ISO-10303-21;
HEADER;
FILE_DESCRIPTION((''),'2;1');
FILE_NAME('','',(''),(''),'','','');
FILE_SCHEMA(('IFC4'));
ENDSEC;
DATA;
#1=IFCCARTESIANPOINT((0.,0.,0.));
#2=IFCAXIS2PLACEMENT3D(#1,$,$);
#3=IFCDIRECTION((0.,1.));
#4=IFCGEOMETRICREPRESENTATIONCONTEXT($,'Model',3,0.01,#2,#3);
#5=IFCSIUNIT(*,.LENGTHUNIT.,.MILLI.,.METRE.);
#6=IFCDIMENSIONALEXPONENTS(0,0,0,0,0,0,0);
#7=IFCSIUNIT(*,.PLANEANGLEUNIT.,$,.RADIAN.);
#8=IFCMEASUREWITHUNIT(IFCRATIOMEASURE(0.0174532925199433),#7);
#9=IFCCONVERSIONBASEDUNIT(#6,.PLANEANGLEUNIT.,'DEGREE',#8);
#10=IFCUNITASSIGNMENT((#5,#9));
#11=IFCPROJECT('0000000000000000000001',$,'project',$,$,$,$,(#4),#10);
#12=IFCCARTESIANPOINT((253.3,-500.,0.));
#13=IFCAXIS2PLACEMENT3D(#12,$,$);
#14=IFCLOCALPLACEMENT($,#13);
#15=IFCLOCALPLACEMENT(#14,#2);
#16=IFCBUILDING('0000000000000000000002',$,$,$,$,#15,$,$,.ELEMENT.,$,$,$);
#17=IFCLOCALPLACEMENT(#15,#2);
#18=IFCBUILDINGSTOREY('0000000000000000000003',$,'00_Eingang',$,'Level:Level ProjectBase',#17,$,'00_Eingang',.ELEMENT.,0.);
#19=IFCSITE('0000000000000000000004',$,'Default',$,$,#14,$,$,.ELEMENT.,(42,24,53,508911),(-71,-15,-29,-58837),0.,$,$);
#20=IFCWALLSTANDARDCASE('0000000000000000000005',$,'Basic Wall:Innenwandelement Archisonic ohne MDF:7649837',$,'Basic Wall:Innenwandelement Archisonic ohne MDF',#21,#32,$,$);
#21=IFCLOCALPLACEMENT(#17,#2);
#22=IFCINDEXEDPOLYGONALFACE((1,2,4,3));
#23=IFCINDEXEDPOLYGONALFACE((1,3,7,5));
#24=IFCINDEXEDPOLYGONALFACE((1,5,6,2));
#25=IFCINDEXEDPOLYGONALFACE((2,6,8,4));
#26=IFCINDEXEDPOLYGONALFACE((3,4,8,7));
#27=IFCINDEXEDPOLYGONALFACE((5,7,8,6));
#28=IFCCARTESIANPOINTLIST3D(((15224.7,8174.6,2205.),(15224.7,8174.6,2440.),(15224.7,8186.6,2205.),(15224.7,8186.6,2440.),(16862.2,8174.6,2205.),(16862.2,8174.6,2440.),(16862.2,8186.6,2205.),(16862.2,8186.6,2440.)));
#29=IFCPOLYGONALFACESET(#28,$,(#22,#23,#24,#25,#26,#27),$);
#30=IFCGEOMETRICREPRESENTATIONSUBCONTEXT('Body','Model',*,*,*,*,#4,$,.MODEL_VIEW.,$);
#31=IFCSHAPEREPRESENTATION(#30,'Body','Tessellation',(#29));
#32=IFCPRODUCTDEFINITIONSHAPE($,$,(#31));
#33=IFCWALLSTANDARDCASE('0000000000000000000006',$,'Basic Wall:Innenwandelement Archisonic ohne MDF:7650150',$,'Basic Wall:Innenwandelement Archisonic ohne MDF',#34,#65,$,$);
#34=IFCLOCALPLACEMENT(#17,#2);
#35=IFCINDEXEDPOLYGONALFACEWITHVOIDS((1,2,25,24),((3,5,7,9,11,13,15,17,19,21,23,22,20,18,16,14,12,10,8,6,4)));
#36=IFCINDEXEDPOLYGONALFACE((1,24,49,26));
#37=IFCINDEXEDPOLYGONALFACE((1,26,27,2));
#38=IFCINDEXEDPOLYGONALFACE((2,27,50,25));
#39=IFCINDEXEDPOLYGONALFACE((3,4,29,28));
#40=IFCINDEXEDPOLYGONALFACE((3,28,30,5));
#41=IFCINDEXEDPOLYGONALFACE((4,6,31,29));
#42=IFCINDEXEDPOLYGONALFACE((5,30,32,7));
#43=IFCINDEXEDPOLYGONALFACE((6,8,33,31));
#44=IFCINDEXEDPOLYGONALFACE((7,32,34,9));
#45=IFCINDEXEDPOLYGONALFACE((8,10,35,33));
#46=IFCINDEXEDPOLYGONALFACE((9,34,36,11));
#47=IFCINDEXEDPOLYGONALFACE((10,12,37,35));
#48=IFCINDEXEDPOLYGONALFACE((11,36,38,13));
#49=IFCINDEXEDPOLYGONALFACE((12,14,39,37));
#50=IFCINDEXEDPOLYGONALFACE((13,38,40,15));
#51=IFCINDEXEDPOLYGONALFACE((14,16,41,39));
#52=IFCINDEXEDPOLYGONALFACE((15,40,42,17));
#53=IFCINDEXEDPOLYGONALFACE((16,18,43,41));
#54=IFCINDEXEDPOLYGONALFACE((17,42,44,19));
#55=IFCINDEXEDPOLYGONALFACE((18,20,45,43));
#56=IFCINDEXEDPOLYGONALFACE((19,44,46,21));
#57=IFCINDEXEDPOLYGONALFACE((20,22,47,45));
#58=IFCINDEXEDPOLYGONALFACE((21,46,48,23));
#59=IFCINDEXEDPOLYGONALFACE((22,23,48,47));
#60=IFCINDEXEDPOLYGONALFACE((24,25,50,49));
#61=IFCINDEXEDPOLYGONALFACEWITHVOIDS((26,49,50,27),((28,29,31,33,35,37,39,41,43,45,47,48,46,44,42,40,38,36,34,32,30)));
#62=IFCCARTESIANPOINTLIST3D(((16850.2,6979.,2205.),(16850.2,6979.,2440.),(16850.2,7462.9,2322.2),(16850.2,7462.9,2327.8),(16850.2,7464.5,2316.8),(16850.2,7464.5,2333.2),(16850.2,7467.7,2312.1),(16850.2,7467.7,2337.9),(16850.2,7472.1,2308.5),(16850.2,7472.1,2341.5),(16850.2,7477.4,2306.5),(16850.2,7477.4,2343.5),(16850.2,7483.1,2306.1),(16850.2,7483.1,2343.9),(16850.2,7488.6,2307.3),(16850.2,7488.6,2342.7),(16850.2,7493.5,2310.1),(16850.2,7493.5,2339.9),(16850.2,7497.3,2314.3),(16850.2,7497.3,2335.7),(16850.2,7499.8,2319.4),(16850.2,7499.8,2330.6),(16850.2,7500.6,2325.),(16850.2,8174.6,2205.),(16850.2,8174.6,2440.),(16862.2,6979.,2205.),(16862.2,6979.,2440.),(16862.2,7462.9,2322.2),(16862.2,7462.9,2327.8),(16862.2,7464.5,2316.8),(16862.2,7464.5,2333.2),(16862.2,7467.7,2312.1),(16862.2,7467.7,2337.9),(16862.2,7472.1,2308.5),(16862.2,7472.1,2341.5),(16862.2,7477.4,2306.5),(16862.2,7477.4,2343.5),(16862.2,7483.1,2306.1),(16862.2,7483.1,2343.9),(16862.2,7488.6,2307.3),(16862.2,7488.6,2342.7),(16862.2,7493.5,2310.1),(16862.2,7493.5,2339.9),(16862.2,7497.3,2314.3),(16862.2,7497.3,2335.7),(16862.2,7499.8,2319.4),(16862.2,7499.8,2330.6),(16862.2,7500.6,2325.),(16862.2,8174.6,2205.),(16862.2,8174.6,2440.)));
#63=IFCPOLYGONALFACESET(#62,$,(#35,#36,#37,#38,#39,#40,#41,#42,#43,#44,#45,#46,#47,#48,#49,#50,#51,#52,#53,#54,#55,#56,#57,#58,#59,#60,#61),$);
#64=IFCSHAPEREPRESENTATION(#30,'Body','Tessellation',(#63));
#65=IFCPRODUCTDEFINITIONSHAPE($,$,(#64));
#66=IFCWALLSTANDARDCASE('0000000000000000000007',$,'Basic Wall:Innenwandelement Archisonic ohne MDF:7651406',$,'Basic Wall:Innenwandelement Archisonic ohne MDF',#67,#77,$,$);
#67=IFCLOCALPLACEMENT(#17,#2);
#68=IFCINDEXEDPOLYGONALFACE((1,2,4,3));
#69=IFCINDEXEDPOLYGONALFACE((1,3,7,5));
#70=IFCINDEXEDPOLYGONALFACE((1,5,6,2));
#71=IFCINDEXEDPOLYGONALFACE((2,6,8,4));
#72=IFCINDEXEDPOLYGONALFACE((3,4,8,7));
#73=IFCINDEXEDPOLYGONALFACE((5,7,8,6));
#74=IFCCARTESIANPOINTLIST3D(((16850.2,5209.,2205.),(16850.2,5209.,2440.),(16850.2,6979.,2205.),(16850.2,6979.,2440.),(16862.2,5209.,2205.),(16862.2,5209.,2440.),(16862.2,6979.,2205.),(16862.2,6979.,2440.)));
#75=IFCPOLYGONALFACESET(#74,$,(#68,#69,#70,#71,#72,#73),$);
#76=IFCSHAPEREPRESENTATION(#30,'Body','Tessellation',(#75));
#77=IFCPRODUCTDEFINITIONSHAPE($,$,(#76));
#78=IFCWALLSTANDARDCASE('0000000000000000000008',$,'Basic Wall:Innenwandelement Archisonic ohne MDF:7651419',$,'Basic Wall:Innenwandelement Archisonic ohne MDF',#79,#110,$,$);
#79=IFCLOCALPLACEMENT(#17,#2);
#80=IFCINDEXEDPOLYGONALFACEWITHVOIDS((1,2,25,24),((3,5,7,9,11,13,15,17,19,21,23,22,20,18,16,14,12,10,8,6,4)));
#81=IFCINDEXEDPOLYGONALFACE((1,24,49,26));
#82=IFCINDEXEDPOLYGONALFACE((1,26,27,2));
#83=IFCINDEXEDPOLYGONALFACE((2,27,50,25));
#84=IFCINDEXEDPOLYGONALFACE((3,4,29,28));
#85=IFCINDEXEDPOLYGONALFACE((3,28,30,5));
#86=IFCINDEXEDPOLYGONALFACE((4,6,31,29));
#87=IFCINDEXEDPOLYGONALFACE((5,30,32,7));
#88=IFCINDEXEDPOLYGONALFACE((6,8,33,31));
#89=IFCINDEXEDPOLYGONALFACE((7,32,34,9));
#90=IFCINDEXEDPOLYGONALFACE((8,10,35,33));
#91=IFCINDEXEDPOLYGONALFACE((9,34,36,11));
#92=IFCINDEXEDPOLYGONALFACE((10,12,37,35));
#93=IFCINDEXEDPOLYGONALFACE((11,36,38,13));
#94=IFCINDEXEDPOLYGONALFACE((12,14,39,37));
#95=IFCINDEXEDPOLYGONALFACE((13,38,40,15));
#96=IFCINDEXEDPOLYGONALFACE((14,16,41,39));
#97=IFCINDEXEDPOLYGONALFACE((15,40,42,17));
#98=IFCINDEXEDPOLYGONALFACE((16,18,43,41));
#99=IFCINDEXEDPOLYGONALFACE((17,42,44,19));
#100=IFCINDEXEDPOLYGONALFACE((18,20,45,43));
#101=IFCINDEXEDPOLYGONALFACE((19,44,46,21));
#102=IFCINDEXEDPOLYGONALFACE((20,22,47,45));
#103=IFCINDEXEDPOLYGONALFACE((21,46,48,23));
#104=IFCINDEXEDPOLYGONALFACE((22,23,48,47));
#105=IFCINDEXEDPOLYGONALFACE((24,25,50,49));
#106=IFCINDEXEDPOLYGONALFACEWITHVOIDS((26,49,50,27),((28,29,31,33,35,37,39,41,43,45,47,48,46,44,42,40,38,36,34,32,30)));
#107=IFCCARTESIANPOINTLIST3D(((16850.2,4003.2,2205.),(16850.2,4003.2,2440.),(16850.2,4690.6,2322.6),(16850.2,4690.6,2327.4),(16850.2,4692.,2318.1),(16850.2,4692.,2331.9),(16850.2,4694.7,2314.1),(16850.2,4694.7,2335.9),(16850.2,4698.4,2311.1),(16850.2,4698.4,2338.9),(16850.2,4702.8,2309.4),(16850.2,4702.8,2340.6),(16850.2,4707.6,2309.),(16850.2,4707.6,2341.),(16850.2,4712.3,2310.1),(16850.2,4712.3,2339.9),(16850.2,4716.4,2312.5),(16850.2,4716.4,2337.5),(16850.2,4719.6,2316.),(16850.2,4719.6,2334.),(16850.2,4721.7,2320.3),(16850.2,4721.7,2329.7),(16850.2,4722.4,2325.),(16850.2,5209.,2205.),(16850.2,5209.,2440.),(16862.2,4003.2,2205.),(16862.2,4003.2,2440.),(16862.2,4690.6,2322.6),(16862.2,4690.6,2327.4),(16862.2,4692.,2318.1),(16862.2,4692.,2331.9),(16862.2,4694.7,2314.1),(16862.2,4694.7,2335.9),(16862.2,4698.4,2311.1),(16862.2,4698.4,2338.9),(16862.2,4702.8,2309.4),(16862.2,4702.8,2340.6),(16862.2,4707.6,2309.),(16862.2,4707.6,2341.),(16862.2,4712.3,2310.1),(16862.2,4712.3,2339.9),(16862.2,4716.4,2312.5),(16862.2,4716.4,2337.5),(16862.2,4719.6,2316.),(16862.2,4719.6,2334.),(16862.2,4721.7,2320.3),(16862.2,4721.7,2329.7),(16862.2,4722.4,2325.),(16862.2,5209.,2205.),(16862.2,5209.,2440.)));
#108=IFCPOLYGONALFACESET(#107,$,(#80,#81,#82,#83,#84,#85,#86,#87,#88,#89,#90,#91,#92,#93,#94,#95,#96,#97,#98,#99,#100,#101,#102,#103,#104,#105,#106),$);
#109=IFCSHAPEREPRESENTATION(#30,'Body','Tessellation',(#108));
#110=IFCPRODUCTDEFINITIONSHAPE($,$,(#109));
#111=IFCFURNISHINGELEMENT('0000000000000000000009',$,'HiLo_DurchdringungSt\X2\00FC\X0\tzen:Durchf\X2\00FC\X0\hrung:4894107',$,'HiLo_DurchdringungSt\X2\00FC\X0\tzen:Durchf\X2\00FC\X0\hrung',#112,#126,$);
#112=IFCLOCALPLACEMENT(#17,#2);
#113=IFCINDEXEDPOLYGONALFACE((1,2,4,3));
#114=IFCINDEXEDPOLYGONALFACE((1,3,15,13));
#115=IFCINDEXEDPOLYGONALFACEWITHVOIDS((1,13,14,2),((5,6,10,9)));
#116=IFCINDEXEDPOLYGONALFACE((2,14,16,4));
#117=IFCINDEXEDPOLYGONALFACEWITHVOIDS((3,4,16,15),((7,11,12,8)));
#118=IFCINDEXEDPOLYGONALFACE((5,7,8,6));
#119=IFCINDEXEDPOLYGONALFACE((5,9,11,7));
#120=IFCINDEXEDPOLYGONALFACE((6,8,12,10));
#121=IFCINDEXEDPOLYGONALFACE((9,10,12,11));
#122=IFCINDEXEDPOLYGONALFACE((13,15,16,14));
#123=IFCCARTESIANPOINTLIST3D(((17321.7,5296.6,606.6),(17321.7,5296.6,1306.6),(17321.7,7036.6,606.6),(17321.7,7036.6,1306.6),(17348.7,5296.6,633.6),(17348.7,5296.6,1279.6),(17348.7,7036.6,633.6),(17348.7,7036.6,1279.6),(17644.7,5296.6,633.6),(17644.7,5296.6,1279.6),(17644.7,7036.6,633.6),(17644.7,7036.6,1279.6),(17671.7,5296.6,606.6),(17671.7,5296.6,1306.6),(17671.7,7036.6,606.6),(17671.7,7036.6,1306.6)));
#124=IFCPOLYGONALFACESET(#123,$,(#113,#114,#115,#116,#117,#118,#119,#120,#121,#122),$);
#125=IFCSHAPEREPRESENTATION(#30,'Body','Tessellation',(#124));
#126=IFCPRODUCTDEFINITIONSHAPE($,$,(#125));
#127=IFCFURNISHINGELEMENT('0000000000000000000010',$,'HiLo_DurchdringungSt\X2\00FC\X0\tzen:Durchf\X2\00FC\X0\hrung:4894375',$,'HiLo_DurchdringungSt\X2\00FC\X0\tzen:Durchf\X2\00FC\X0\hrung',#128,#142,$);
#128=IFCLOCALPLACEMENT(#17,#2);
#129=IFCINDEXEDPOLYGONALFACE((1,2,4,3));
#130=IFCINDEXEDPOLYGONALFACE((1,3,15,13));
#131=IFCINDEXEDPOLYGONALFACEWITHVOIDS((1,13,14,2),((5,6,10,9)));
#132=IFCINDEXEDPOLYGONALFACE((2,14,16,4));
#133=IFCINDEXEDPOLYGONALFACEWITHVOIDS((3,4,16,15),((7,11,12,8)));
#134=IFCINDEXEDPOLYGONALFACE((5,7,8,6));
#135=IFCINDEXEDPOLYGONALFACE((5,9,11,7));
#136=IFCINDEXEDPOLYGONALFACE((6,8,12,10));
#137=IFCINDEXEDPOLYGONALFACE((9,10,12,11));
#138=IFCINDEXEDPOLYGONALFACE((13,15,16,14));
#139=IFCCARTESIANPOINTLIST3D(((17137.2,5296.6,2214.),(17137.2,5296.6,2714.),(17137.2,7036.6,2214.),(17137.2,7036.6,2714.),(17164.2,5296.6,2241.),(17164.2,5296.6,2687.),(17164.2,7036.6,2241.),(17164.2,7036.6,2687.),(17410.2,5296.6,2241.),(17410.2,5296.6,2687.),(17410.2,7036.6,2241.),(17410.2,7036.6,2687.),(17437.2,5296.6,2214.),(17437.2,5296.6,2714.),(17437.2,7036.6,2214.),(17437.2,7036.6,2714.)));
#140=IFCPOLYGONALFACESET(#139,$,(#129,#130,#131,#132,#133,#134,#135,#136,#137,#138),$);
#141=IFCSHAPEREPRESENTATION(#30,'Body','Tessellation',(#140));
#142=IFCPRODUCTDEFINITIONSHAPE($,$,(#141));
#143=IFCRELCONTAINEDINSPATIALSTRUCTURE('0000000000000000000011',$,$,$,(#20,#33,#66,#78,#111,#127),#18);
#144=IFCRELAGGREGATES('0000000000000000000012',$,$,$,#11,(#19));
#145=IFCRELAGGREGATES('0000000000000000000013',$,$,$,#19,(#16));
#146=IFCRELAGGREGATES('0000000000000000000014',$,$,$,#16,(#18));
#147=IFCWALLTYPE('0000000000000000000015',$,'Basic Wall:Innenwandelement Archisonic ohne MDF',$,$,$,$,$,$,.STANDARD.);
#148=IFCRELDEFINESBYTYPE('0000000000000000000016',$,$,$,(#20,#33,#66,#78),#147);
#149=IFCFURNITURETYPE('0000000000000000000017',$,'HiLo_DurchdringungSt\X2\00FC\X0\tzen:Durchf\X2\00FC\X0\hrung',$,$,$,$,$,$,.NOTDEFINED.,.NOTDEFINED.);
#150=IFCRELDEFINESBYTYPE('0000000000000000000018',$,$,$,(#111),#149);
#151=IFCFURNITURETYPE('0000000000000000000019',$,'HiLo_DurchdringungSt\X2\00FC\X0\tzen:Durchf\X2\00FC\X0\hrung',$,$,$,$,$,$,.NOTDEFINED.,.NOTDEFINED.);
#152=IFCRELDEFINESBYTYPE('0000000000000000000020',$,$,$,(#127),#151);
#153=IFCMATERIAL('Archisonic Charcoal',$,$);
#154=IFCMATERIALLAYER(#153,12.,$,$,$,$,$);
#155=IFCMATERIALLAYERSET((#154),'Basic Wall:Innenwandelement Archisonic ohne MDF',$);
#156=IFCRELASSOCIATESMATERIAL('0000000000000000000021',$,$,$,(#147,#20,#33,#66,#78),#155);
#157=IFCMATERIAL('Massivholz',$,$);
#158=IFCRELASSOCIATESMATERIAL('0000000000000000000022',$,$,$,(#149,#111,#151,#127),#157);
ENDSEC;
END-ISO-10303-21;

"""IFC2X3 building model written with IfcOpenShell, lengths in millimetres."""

from ifc_helpers import new_model, entity, si_unit, converted_unit, direction, frame, frame_2d, origin, origin_2d_with_axis, place, context, subcontext, project, spatial, polyline, rectangle, circle, outline, extrude, source, transform, mapped, material, layer, layer_set, layer_usage, type_object, type_shapes, element, save


model = new_model("IFC2X3")

# Units and contexts
model_context = context("Model", 3, precision=0.01, world=origin(), true_north=direction((0.0, 1.0)))
body_context = subcontext(model_context, "Body", "Model", "MODEL_VIEW")
ifc_project = project(units=[si_unit("LENGTHUNIT", "METRE", prefix="MILLI"), converted_unit("PLANEANGLEUNIT", "DEGREE", entity("IfcRatioMeasure", 0.0174532925199433), si_unit("PLANEANGLEUNIT", "RADIAN"), dimensions=[0, 0, 0, 0, 0, 0, 0])], contexts=[model_context])

# Site, building, storey
site_placement = place(None, frame((253.3, -500.0, 0.0)))
site = spatial("IfcSite", under=ifc_project, at=site_placement, Name="Default", CompositionType="ELEMENT", RefLatitude=(42, 24, 53, 508911), RefLongitude=(-71, -15, -29, -58837), RefElevation=0.0)
building_placement = place(site_placement, origin())
building = spatial("IfcBuilding", under=site, at=building_placement, CompositionType="ELEMENT")
storey_placement = place(building_placement, origin())
storey = spatial("IfcBuildingStorey", under=building, at=storey_placement, Name="00_Eingang", ObjectType="Level:Level ProjectBase", LongName="00_Eingang", CompositionType="ELEMENT", Elevation=0.0)

# Shared definitions
ifc_material_1 = material(Name="Archisonic Charcoal")

# Wall
ifc_layer_1 = layer(ifc_material_1, 12.0)
ifc_layer_set_1 = layer_set([ifc_layer_1], Name="Basic Wall:Innenwandelement Archisonic ohne MDF")
wall_type_1 = type_object("IfcWallType", Name="Basic Wall:Innenwandelement Archisonic ohne MDF", PredefinedType="STANDARD", material=ifc_layer_set_1)
ifc_layer_usage_1 = layer_usage(ifc_layer_set_1, "AXIS2", "POSITIVE", -6.0)
wall_1_placement = place(storey_placement, frame((15224.7, 8180.6, 2205.0)))
element("IfcWallStandardCase", 1, at=wall_1_placement, inside=storey, type_object=wall_type_1, material=ifc_layer_usage_1, Name="Basic Wall:Innenwandelement Archisonic ohne MDF:7649837", ObjectType="Basic Wall:Innenwandelement Archisonic ohne MDF", context=body_context, shape_type="SweptSolid", body=[
    extrude(rectangle(XDim=1637.5, YDim=12.0, at=frame_2d((818.7, 0.0), x_axis=(-1.0, 0.0))), origin(), (0.0, 0.0, 1.0), 235.0),
])

# Wall, opening
ifc_layer_usage_2 = layer_usage(ifc_layer_set_1, "AXIS2", "POSITIVE", -6.0)
wall_2_placement = place(storey_placement, frame((16856.2, 8174.6, 2205.0), z_axis=(0.0, 0.0, 1.0), x_axis=(0.0, -1.0, 0.0)))
wall_2 = element("IfcWallStandardCase", 2, at=wall_2_placement, inside=storey, type_object=wall_type_1, material=ifc_layer_usage_2, Name="Basic Wall:Innenwandelement Archisonic ohne MDF:7650150", ObjectType="Basic Wall:Innenwandelement Archisonic ohne MDF", context=body_context, shape_type="SweptSolid", body=[
    extrude(rectangle(XDim=1195.6, YDim=12.0, at=frame_2d((597.8, 0.0), x_axis=(-1.0, 0.0))), origin(), (0.0, 0.0, 1.0), 235.0),
])
opening_1_placement = place(wall_2_placement, frame((713.6, -339.8, 99.4)))
element("IfcOpeningElement", 3, at=opening_1_placement, cuts=wall_2, ObjectType="Opening", context=body_context, shape_type="SweptSolid", body=[
    extrude(circle(Radius=19.0, at=origin_2d_with_axis()), frame((-20.6, 0.0, 20.6), z_axis=(-0.000001, 1.0, 0.0), x_axis=(-1.0, -0.000001, 0.0)), (0.0, 0.0, 1.0), 782.8),
])

# Wall
ifc_layer_usage_3 = layer_usage(ifc_layer_set_1, "AXIS2", "NEGATIVE", 6.0)
wall_3_placement = place(storey_placement, frame((16856.2, 5209.0, 2205.0), z_axis=(0.0, 0.0, 1.0), x_axis=(0.0, 1.0, 0.0)))
element("IfcWallStandardCase", 4, at=wall_3_placement, inside=storey, type_object=wall_type_1, material=ifc_layer_usage_3, Name="Basic Wall:Innenwandelement Archisonic ohne MDF:7651406", ObjectType="Basic Wall:Innenwandelement Archisonic ohne MDF", context=body_context, shape_type="SweptSolid", body=[
    extrude(rectangle(XDim=1770.0, YDim=12.0, at=frame_2d((885.0, 0.0), x_axis=(-1.0, 0.0))), origin(), (0.0, 0.0, 1.0), 235.0),
])

# Wall, opening
ifc_layer_usage_4 = layer_usage(ifc_layer_set_1, "AXIS2", "POSITIVE", -6.0)
wall_4_placement = place(storey_placement, frame((16856.2, 5209.0, 2205.0), z_axis=(0.0, 0.0, 1.0), x_axis=(0.0, -1.0, 0.0)))
wall_4 = element("IfcWallStandardCase", 5, at=wall_4_placement, inside=storey, type_object=wall_type_1, material=ifc_layer_usage_4, Name="Basic Wall:Innenwandelement Archisonic ohne MDF:7651419", ObjectType="Basic Wall:Innenwandelement Archisonic ohne MDF", context=body_context, shape_type="SweptSolid", body=[
    extrude(rectangle(XDim=1205.8, YDim=12.0, at=frame_2d((602.9, 0.0), x_axis=(-1.0, 0.0))), origin(), (0.0, 0.0, 1.0), 235.0),
])
opening_2_placement = place(wall_4_placement, frame((520.2, -339.8, 102.4)))
element("IfcOpeningElement", 6, at=opening_2_placement, cuts=wall_4, ObjectType="Opening", context=body_context, shape_type="SweptSolid", body=[
    extrude(circle(Radius=16.0, at=origin_2d_with_axis()), frame((-17.6, 0.0, 17.6), z_axis=(0.0, 1.0, 0.0), x_axis=(-1.0, 0.0, 0.0)), (0.0, 0.0, 1.0), 782.8),
])

# Furnishing elements
ifc_material_2 = material(Name="Massivholz")
furniture_type_1 = type_object("IfcFurnitureType", Name="HiLo_DurchdringungStützen:Durchführung", material=ifc_material_2)
shared_shape_1 = source(origin(), body_context, "Body", "SweptSolid", [
    extrude(outline(polyline([(-350.0, -175.0), (350.0, -175.0), (350.0, 175.0), (-350.0, 175.0), (-350.0, -175.0)]), holes=[polyline([(323.0, -148.0), (-323.0, -148.0), (-323.0, 148.0), (323.0, 148.0), (323.0, -148.0)])]), frame((0.0, -175.0, 0.0), z_axis=(1.0, 0.0, 0.0), x_axis=(0.0, 0.0, -1.0)), (0.0, 0.0, 1.0), 1740.0),
])
type_shapes(furniture_type_1, [shared_shape_1])
furnishing_1_placement = place(storey_placement, frame((17321.7, 5296.6, 956.6), z_axis=(0.0, 0.0, 1.0), x_axis=(0.0, 1.0, 0.0)))
element("IfcFurnishingElement", 7, at=furnishing_1_placement, inside=storey, type_object=furniture_type_1, material=ifc_material_2, Name="HiLo_DurchdringungStützen:Durchführung:4894107", ObjectType="HiLo_DurchdringungStützen:Durchführung", context=body_context, shape_type="MappedRepresentation", body=[
    mapped(shared_shape_1, transform((0.0, 0.0, 0.0), scale=1.0)),
])
furniture_type_2 = type_object("IfcFurnitureType", Name="HiLo_DurchdringungStützen:Durchführung", material=ifc_material_2)
shared_shape_2 = source(origin(), body_context, "Body", "SweptSolid", [
    extrude(outline(polyline([(-250.0, -150.0), (250.0, -150.0), (250.0, 150.0), (-250.0, 150.0), (-250.0, -150.0)]), holes=[polyline([(223.0, -123.0), (-223.0, -123.0), (-223.0, 123.0), (223.0, 123.0), (223.0, -123.0)])]), frame((0.0, -150.0, 0.0), z_axis=(1.0, 0.0, 0.0), x_axis=(0.0, 0.0, -1.0)), (0.0, 0.0, 1.0), 1740.0),
])
type_shapes(furniture_type_2, [shared_shape_2])
furnishing_2_placement = place(storey_placement, frame((17137.2, 5296.6, 2464.0), z_axis=(0.0, 0.0, 1.0), x_axis=(0.0, 1.0, 0.0)))
element("IfcFurnishingElement", 8, at=furnishing_2_placement, inside=storey, type_object=furniture_type_2, material=ifc_material_2, Name="HiLo_DurchdringungStützen:Durchführung:4894375", ObjectType="HiLo_DurchdringungStützen:Durchführung", context=body_context, shape_type="MappedRepresentation", body=[
    mapped(shared_shape_2, transform((0.0, 0.0, 0.0), scale=1.0)),
])

save(model, "model.ifc")
